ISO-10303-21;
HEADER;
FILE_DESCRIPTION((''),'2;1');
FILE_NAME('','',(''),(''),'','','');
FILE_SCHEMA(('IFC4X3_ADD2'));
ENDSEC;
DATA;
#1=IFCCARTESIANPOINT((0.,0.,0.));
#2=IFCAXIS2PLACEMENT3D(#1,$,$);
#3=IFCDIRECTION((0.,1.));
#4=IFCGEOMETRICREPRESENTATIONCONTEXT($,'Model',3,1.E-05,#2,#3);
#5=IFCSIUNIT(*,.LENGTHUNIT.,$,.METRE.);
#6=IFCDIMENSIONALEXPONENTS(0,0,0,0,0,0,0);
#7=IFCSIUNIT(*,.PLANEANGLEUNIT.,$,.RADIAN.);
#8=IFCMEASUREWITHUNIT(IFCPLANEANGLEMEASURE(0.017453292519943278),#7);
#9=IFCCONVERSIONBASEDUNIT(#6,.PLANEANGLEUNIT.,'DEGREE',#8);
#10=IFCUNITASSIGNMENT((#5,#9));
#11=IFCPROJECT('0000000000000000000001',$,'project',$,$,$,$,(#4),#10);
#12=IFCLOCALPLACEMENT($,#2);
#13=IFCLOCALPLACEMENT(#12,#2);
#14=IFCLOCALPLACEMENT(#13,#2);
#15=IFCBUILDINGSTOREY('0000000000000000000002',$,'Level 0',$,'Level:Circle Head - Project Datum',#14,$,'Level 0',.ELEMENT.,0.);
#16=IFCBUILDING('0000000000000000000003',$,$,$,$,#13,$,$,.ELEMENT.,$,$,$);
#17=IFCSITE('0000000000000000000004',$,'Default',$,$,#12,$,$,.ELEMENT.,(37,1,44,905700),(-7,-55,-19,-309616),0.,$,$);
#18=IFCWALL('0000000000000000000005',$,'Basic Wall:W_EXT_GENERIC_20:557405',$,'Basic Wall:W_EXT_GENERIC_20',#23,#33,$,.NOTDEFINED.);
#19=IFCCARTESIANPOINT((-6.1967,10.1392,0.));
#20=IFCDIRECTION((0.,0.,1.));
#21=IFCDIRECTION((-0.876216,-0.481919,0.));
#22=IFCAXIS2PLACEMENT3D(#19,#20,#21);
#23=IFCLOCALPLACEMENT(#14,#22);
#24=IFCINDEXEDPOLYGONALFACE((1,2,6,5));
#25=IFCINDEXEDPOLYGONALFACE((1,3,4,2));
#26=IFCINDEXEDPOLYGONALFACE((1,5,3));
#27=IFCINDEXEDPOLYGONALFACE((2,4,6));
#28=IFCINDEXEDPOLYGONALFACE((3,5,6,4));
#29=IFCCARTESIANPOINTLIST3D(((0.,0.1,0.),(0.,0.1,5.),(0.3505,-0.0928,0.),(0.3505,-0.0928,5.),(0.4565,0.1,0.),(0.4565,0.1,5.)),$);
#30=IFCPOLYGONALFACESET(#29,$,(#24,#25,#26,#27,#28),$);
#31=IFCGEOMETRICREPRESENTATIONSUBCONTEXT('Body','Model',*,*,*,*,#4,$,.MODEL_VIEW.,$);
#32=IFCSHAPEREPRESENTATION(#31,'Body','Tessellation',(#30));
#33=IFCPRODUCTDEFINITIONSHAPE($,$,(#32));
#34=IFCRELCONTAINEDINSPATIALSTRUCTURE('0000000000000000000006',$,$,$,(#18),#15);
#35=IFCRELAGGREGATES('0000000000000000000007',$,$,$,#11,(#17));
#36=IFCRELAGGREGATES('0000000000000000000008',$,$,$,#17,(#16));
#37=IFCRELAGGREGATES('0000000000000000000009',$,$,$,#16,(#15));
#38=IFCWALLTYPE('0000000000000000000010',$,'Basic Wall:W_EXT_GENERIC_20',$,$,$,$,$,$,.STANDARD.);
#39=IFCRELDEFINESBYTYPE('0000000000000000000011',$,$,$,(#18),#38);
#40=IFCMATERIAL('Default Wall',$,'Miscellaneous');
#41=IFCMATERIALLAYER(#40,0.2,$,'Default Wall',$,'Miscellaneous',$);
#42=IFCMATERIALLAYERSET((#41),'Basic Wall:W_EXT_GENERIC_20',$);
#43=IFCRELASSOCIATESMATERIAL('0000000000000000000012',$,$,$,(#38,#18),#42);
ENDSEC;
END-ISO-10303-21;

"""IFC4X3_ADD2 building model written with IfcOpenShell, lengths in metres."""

from ifc_helpers import new_model, entity, si_unit, converted_unit, direction, frame, origin, place, context, subcontext, project, spatial, polyline, outline, extrude, material, layer, layer_set, type_object, element, save


model = new_model("IFC4X3_ADD2")

# Units and contexts
model_context = context("Model", 3, precision=1e-05, world=origin(), true_north=direction((0.0, 1.0)))
body_context = subcontext(model_context, "Body", "Model", "MODEL_VIEW")
ifc_project = project(units=[si_unit("LENGTHUNIT", "METRE"), converted_unit("PLANEANGLEUNIT", "DEGREE", entity("IfcPlaneAngleMeasure", 0.017453292519943278), si_unit("PLANEANGLEUNIT", "RADIAN"), dimensions=[0, 0, 0, 0, 0, 0, 0])], contexts=[model_context])

# Site, building, storey
site_placement = place(None, origin())
site = spatial("IfcSite", under=ifc_project, at=site_placement, Name="Default", CompositionType="ELEMENT", RefLatitude=(37, 1, 44, 905700), RefLongitude=(-7, -55, -19, -309616), RefElevation=0.0)
building_placement = place(site_placement, origin())
building = spatial("IfcBuilding", under=site, at=building_placement, CompositionType="ELEMENT")
storey_placement = place(building_placement, origin())
storey = spatial("IfcBuildingStorey", under=building, at=storey_placement, Name="Level 0", ObjectType="Level:Circle Head - Project Datum", LongName="Level 0", CompositionType="ELEMENT", Elevation=0.0)

# Shared definitions
ifc_material_1 = material(Name="Default Wall", Category="Miscellaneous")

# Wall
ifc_layer_1 = layer(ifc_material_1, 0.2, Name="Default Wall", Category="Miscellaneous")
ifc_layer_set_1 = layer_set([ifc_layer_1], Name="Basic Wall:W_EXT_GENERIC_20")
wall_type_1 = type_object("IfcWallType", Name="Basic Wall:W_EXT_GENERIC_20", PredefinedType="STANDARD", material=ifc_layer_set_1)
wall_1_placement = place(storey_placement, frame((-6.1967, 10.1392, 0.0), z_axis=(0.0, 0.0, 1.0), x_axis=(-0.876216, -0.481919, 0.0)))
element("IfcWall", 1, at=wall_1_placement, inside=storey, type_object=wall_type_1, material=ifc_layer_set_1, Name="Basic Wall:W_EXT_GENERIC_20:557405", ObjectType="Basic Wall:W_EXT_GENERIC_20", PredefinedType="NOTDEFINED", context=body_context, shape_type="SweptSolid", body=[
    extrude(outline(polyline([(0.0, 0.1), (0.3505, -0.0928), (0.4565, 0.1), (0.0, 0.1)])), origin(), (0.0, 0.0, 1.0), 5.0),
])

save(model, "model.ifc")
